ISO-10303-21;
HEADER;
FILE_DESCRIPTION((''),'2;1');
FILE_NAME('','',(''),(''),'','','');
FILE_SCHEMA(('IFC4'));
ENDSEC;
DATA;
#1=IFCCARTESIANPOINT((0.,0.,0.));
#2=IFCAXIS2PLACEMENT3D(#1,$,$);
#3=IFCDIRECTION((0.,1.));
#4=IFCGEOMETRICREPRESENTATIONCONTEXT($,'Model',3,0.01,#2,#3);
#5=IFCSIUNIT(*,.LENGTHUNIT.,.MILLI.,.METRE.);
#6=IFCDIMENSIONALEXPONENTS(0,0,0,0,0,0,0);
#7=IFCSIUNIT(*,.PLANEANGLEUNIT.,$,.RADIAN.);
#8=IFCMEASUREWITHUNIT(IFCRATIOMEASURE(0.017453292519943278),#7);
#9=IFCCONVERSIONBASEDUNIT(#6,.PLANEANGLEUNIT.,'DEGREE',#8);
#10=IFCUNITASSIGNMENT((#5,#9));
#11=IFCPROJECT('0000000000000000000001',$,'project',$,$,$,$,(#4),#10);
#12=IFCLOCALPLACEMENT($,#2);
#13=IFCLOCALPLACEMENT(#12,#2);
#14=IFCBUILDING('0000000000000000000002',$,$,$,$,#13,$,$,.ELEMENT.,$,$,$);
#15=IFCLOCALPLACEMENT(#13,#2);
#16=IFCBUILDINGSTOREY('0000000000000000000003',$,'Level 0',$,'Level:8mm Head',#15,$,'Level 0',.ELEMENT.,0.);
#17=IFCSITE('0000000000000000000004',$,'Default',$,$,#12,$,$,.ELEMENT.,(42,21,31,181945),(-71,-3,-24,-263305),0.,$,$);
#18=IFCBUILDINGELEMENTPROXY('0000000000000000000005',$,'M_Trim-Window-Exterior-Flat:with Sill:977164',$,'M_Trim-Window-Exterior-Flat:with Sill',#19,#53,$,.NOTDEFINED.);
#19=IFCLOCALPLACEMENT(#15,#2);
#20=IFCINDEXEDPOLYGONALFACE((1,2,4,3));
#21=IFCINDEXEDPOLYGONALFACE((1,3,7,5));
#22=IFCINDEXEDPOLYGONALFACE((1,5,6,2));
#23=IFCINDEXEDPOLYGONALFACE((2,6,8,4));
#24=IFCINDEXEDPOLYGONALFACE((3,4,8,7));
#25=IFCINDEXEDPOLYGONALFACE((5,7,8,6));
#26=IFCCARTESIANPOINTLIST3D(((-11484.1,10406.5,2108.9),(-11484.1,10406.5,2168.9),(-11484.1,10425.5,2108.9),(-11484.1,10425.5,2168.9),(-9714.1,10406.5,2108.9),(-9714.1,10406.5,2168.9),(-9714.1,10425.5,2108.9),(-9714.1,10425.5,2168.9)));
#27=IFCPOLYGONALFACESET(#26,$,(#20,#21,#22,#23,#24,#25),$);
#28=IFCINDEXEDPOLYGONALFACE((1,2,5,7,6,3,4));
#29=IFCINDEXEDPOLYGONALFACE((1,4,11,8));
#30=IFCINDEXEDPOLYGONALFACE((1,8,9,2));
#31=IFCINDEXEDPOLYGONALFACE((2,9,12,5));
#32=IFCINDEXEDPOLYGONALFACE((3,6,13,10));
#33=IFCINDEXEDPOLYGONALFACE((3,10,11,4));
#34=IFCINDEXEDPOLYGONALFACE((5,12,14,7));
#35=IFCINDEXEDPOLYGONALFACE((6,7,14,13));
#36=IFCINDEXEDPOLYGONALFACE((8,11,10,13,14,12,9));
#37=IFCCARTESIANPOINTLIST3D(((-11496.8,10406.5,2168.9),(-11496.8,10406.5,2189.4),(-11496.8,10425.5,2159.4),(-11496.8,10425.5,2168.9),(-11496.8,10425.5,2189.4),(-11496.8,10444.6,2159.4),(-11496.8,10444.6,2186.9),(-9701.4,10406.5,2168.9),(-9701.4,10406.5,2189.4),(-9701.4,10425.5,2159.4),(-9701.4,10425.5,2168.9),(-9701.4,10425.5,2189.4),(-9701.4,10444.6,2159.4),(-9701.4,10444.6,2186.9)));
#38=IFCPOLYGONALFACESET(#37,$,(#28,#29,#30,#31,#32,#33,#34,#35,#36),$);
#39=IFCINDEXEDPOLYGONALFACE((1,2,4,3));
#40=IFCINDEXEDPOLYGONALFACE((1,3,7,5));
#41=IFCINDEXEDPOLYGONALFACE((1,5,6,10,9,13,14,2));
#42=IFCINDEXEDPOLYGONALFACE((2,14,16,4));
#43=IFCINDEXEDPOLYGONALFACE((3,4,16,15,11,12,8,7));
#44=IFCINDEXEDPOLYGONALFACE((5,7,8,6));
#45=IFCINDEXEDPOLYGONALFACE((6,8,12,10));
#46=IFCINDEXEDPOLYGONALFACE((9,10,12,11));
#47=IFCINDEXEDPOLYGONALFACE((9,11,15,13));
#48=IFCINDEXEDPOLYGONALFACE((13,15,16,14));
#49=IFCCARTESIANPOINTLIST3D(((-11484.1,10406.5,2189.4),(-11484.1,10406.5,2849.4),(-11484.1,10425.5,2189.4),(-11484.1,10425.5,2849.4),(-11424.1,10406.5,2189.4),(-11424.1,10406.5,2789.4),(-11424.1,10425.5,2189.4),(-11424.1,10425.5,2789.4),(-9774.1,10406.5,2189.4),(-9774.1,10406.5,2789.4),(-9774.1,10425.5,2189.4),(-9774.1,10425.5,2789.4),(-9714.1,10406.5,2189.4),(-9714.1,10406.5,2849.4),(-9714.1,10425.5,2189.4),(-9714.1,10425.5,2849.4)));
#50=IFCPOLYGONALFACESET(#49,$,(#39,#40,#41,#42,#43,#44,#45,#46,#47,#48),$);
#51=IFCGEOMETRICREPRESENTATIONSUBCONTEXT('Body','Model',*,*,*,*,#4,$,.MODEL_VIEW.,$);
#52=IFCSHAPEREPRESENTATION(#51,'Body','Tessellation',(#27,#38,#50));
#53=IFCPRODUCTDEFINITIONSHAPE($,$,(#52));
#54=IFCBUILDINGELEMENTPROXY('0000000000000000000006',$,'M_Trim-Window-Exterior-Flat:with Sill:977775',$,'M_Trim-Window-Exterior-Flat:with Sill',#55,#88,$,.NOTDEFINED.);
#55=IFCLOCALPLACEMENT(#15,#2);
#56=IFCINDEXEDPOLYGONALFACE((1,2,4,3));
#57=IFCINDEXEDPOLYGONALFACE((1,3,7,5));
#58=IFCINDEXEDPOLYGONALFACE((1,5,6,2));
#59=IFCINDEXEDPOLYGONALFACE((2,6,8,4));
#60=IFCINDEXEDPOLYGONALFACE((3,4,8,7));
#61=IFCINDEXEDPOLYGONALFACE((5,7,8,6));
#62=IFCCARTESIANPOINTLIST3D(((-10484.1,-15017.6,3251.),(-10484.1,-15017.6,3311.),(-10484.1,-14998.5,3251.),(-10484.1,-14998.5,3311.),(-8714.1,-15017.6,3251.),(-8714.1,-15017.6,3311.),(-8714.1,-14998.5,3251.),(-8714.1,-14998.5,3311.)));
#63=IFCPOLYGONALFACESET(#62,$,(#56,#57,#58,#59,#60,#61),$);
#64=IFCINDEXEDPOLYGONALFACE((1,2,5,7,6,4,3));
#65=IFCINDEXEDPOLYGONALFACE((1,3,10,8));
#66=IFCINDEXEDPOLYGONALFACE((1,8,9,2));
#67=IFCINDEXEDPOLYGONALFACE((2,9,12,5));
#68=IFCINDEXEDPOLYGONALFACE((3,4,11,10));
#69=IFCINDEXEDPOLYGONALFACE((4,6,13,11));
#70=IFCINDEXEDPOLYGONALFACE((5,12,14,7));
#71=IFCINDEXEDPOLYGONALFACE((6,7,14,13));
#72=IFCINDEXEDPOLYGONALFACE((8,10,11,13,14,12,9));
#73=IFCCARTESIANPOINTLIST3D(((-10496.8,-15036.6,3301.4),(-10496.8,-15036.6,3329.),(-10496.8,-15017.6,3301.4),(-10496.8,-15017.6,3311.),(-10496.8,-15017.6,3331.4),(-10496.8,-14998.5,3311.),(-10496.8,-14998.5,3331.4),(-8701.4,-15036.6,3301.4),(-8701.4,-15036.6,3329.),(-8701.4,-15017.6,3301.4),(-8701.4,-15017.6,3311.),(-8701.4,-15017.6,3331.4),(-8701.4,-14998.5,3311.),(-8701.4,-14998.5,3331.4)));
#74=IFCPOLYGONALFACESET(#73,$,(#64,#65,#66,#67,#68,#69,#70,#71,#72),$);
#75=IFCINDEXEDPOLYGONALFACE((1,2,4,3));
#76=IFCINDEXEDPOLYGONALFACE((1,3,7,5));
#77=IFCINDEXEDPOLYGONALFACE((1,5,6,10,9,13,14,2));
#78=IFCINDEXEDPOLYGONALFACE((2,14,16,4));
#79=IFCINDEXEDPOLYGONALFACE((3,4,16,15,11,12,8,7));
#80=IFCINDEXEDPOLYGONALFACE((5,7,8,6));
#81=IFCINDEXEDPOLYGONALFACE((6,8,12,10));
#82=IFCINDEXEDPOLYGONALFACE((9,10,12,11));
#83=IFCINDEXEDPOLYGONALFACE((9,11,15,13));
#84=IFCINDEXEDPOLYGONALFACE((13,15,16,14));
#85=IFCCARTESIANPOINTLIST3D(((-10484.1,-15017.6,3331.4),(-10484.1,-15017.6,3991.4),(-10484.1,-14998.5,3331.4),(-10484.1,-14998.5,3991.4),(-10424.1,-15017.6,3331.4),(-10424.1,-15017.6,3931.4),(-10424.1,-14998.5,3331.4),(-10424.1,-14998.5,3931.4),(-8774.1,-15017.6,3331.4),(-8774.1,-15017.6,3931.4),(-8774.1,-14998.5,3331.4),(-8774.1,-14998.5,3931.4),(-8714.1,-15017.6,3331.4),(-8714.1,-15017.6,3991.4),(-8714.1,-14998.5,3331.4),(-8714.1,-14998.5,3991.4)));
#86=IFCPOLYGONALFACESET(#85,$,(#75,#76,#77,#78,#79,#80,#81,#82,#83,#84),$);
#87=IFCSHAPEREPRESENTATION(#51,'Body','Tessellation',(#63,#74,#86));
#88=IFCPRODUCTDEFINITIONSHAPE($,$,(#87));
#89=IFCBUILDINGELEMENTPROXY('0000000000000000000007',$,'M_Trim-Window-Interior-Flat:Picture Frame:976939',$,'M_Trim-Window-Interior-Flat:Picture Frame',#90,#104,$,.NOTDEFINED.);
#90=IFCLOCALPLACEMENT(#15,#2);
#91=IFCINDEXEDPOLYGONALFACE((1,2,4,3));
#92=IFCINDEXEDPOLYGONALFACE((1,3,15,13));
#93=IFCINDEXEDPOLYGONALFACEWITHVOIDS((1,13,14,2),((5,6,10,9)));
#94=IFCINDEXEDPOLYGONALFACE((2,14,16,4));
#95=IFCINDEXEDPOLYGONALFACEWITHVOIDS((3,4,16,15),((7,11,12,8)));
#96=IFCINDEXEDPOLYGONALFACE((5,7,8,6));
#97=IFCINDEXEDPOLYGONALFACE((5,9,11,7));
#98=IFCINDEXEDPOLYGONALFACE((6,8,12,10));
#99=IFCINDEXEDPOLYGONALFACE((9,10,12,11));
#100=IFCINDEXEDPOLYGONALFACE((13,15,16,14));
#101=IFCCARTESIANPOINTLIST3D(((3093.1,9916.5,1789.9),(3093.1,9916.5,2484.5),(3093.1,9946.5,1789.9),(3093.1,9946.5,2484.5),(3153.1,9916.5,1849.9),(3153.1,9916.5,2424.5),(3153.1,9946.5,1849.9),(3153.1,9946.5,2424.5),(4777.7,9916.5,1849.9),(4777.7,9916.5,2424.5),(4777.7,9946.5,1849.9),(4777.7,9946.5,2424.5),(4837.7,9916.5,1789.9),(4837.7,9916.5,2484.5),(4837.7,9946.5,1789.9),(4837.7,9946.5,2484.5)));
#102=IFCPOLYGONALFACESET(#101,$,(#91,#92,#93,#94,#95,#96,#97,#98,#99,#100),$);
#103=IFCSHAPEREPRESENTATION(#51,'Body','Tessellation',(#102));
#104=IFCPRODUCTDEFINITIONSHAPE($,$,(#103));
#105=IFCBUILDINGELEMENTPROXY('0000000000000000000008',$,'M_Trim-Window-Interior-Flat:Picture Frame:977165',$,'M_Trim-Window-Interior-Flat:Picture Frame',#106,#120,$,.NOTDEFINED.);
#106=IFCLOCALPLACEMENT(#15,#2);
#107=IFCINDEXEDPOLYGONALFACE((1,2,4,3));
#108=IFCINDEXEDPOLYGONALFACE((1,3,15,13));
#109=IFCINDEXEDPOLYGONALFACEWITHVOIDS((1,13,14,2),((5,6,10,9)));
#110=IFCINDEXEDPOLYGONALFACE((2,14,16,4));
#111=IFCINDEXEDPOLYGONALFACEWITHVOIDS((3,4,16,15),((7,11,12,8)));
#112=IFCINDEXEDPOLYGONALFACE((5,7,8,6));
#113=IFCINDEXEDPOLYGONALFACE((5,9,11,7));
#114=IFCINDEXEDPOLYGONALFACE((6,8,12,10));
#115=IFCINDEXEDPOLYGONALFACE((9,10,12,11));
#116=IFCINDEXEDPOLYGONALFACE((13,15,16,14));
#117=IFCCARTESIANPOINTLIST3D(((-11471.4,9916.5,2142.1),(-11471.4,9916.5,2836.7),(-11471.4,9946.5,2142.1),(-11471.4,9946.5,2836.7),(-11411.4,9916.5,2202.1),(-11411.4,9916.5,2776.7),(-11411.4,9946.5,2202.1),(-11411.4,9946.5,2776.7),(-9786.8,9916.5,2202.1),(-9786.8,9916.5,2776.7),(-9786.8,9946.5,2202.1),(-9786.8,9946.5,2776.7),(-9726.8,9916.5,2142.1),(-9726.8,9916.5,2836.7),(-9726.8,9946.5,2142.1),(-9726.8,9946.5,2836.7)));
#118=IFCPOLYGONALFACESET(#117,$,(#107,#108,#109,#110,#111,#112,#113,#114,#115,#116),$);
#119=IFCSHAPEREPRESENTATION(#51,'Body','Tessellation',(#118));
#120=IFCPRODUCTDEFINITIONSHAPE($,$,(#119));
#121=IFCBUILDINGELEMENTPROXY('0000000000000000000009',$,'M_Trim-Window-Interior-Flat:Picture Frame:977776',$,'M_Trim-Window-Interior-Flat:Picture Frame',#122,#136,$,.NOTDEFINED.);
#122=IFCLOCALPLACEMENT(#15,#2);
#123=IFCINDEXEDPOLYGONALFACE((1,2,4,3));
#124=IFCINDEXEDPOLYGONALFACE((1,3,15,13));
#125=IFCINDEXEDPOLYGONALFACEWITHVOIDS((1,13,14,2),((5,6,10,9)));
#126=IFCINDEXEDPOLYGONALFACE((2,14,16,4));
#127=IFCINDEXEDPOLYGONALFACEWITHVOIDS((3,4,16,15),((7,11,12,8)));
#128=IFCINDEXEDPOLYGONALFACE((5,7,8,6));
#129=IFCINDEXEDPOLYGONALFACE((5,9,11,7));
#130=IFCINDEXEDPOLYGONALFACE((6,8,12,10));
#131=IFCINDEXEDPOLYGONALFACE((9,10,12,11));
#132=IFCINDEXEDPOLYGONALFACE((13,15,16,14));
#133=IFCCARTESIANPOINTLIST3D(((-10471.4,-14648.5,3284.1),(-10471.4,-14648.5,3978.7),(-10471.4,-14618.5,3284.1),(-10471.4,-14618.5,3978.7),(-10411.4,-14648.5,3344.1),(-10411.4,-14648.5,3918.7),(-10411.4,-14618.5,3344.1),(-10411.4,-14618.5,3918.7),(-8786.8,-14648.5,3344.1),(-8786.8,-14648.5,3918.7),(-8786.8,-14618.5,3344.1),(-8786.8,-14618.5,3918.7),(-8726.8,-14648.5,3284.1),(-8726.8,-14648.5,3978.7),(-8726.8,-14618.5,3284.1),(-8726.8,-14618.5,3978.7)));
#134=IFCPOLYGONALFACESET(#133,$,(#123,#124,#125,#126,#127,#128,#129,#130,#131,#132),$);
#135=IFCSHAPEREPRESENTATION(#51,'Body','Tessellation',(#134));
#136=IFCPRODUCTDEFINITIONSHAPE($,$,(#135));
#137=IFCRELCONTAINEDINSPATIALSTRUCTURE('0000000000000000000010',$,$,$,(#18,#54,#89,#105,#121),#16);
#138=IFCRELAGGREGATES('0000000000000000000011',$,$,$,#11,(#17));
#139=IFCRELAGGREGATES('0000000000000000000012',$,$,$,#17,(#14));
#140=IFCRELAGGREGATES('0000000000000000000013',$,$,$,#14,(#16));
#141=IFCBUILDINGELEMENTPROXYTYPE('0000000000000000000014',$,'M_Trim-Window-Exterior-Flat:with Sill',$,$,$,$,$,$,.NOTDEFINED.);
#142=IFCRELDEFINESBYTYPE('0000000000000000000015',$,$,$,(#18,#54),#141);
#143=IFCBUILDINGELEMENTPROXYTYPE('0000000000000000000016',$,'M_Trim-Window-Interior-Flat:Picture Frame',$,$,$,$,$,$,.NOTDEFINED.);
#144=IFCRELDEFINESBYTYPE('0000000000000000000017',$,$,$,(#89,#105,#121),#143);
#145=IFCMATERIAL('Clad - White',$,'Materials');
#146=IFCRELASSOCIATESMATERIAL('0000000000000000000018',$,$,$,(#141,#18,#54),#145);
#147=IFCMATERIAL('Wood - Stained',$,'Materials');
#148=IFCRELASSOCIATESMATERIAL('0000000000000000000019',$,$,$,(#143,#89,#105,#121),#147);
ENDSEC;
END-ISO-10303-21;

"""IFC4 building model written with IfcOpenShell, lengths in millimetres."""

from ifc_helpers import new_model, entity, si_unit, converted_unit, direction, frame, frame_2d, origin, place, context, subcontext, project, spatial, polyline, rectangle, outline, extrude, source, transform, mapped, material, type_object, type_shapes, element, save


model = new_model("IFC4")

# Units and contexts
model_context = context("Model", 3, precision=0.01, world=origin(), true_north=direction((0.0, 1.0)))
body_context = subcontext(model_context, "Body", "Model", "MODEL_VIEW")
ifc_project = project(units=[si_unit("LENGTHUNIT", "METRE", prefix="MILLI"), converted_unit("PLANEANGLEUNIT", "DEGREE", entity("IfcRatioMeasure", 0.017453292519943278), si_unit("PLANEANGLEUNIT", "RADIAN"), dimensions=[0, 0, 0, 0, 0, 0, 0])], contexts=[model_context])

# Site, building, storey
site_placement = place(None, origin())
site = spatial("IfcSite", under=ifc_project, at=site_placement, Name="Default", CompositionType="ELEMENT", RefLatitude=(42, 21, 31, 181945), RefLongitude=(-71, -3, -24, -263305), RefElevation=0.0)
building_placement = place(site_placement, origin())
building = spatial("IfcBuilding", under=site, at=building_placement, CompositionType="ELEMENT")
storey_placement = place(building_placement, origin())
storey = spatial("IfcBuildingStorey", under=building, at=storey_placement, Name="Level 0", ObjectType="Level:8mm Head", LongName="Level 0", CompositionType="ELEMENT", Elevation=0.0)

# Building element proxies
ifc_material_1 = material(Name="Clad - White", Category="Materials")
building_element_proxy_type_1 = type_object("IfcBuildingElementProxyType", Name="M_Trim-Window-Exterior-Flat:with Sill", PredefinedType="NOTDEFINED", material=ifc_material_1)
shared_shape_1 = source(origin(), body_context, "Body", "SweptSolid", [
    extrude(rectangle(XDim=1770.0, YDim=60.0, at=frame_2d((0.0, 0.0), x_axis=(1.0, 0.0))), frame((0.0, -650.4, 0.0), z_axis=(0.0, 0.0, 1.0), x_axis=(-1.0, 0.0, 0.0)), (0.0, 0.0, 1.0), 19.0),
    extrude(outline(polyline([(-19.0, -15.2), (0.0, -15.2), (0.0, -5.7), (19.0, -5.7), (19.0, 14.8), (0.0, 14.8), (-19.0, 12.3), (-19.0, -15.2)])), frame((-897.7, -614.8, 19.0), z_axis=(1.0, 0.0, 0.0), x_axis=(0.0, 0.0, -1.0)), (0.0, 0.0, 1.0), 1795.4),
    extrude(outline(polyline([(-345.0, -885.0), (315.0, -885.0), (315.0, -825.0), (-285.0, -825.0), (-285.0, 825.0), (315.0, 825.0), (315.0, 885.0), (-345.0, 885.0), (-345.0, -885.0)])), frame((0.0, -285.0, 0.0), z_axis=(0.0, 0.0, 1.0), x_axis=(0.0, -1.0, 0.0)), (0.0, 0.0, 1.0), 19.0),
])
type_shapes(building_element_proxy_type_1, [shared_shape_1])
for number, where, z_axis, x_axis, name in (
    (1, (-10599.1, 10406.5, 2789.4), (0.0, 1.0, 0.0), (-1.0, 0.0, 0.0), "M_Trim-Window-Exterior-Flat:with Sill:977164"),
    (2, (-9599.1, -14998.5, 3931.4), (0.0, -1.0, 0.0), (1.0, 0.0, 0.0), "M_Trim-Window-Exterior-Flat:with Sill:977775"),
):
    element("IfcBuildingElementProxy", number, at=place(storey_placement, frame(where, z_axis=z_axis, x_axis=x_axis)), inside=storey, type_object=building_element_proxy_type_1, material=ifc_material_1, Name=name, ObjectType="M_Trim-Window-Exterior-Flat:with Sill", PredefinedType="NOTDEFINED", context=body_context, shape_type="MappedRepresentation", body=[
        mapped(shared_shape_1, transform((0.0, 0.0, 0.0), scale=1.0)),
    ])
ifc_material_2 = material(Name="Wood - Stained", Category="Materials")
building_element_proxy_type_2 = type_object("IfcBuildingElementProxyType", Name="M_Trim-Window-Interior-Flat:Picture Frame", PredefinedType="NOTDEFINED", material=ifc_material_2)
shared_shape_2 = source(origin(), body_context, "Body", "SweptSolid", [
    extrude(outline(polyline([(-872.3, -347.3), (872.3, -347.3), (872.3, 347.3), (-872.3, 347.3), (-872.3, -347.3)]), holes=[polyline([(-812.3, -287.3), (-812.3, 287.3), (812.3, 287.3), (812.3, -287.3), (-812.3, -287.3)])]), frame((0.0, -300.0, 0.0), z_axis=(0.0, 0.0, 1.0), x_axis=(-1.0, 0.0, 0.0)), (0.0, 0.0, 1.0), 30.0),
])
type_shapes(building_element_proxy_type_2, [shared_shape_2])
for number, where, z_axis, x_axis, name in (
    (3, (3965.4, 9946.5, 2437.2), (0.0, -1.0, 0.0), (1.0, 0.0, 0.0), "M_Trim-Window-Interior-Flat:Picture Frame:976939"),
    (4, (-10599.1, 9946.5, 2789.4), (0.0, -1.0, 0.0), (1.0, 0.0, 0.0), "M_Trim-Window-Interior-Flat:Picture Frame:977165"),
    (5, (-9599.1, -14648.5, 3931.4), (0.0, 1.0, 0.0), (-1.0, 0.0, 0.0), "M_Trim-Window-Interior-Flat:Picture Frame:977776"),
):
    element("IfcBuildingElementProxy", number, at=place(storey_placement, frame(where, z_axis=z_axis, x_axis=x_axis)), inside=storey, type_object=building_element_proxy_type_2, material=ifc_material_2, Name=name, ObjectType="M_Trim-Window-Interior-Flat:Picture Frame", PredefinedType="NOTDEFINED", context=body_context, shape_type="MappedRepresentation", body=[
        mapped(shared_shape_2, transform((0.0, 0.0, 0.0), scale=1.0)),
    ])

save(model, "model.ifc")
